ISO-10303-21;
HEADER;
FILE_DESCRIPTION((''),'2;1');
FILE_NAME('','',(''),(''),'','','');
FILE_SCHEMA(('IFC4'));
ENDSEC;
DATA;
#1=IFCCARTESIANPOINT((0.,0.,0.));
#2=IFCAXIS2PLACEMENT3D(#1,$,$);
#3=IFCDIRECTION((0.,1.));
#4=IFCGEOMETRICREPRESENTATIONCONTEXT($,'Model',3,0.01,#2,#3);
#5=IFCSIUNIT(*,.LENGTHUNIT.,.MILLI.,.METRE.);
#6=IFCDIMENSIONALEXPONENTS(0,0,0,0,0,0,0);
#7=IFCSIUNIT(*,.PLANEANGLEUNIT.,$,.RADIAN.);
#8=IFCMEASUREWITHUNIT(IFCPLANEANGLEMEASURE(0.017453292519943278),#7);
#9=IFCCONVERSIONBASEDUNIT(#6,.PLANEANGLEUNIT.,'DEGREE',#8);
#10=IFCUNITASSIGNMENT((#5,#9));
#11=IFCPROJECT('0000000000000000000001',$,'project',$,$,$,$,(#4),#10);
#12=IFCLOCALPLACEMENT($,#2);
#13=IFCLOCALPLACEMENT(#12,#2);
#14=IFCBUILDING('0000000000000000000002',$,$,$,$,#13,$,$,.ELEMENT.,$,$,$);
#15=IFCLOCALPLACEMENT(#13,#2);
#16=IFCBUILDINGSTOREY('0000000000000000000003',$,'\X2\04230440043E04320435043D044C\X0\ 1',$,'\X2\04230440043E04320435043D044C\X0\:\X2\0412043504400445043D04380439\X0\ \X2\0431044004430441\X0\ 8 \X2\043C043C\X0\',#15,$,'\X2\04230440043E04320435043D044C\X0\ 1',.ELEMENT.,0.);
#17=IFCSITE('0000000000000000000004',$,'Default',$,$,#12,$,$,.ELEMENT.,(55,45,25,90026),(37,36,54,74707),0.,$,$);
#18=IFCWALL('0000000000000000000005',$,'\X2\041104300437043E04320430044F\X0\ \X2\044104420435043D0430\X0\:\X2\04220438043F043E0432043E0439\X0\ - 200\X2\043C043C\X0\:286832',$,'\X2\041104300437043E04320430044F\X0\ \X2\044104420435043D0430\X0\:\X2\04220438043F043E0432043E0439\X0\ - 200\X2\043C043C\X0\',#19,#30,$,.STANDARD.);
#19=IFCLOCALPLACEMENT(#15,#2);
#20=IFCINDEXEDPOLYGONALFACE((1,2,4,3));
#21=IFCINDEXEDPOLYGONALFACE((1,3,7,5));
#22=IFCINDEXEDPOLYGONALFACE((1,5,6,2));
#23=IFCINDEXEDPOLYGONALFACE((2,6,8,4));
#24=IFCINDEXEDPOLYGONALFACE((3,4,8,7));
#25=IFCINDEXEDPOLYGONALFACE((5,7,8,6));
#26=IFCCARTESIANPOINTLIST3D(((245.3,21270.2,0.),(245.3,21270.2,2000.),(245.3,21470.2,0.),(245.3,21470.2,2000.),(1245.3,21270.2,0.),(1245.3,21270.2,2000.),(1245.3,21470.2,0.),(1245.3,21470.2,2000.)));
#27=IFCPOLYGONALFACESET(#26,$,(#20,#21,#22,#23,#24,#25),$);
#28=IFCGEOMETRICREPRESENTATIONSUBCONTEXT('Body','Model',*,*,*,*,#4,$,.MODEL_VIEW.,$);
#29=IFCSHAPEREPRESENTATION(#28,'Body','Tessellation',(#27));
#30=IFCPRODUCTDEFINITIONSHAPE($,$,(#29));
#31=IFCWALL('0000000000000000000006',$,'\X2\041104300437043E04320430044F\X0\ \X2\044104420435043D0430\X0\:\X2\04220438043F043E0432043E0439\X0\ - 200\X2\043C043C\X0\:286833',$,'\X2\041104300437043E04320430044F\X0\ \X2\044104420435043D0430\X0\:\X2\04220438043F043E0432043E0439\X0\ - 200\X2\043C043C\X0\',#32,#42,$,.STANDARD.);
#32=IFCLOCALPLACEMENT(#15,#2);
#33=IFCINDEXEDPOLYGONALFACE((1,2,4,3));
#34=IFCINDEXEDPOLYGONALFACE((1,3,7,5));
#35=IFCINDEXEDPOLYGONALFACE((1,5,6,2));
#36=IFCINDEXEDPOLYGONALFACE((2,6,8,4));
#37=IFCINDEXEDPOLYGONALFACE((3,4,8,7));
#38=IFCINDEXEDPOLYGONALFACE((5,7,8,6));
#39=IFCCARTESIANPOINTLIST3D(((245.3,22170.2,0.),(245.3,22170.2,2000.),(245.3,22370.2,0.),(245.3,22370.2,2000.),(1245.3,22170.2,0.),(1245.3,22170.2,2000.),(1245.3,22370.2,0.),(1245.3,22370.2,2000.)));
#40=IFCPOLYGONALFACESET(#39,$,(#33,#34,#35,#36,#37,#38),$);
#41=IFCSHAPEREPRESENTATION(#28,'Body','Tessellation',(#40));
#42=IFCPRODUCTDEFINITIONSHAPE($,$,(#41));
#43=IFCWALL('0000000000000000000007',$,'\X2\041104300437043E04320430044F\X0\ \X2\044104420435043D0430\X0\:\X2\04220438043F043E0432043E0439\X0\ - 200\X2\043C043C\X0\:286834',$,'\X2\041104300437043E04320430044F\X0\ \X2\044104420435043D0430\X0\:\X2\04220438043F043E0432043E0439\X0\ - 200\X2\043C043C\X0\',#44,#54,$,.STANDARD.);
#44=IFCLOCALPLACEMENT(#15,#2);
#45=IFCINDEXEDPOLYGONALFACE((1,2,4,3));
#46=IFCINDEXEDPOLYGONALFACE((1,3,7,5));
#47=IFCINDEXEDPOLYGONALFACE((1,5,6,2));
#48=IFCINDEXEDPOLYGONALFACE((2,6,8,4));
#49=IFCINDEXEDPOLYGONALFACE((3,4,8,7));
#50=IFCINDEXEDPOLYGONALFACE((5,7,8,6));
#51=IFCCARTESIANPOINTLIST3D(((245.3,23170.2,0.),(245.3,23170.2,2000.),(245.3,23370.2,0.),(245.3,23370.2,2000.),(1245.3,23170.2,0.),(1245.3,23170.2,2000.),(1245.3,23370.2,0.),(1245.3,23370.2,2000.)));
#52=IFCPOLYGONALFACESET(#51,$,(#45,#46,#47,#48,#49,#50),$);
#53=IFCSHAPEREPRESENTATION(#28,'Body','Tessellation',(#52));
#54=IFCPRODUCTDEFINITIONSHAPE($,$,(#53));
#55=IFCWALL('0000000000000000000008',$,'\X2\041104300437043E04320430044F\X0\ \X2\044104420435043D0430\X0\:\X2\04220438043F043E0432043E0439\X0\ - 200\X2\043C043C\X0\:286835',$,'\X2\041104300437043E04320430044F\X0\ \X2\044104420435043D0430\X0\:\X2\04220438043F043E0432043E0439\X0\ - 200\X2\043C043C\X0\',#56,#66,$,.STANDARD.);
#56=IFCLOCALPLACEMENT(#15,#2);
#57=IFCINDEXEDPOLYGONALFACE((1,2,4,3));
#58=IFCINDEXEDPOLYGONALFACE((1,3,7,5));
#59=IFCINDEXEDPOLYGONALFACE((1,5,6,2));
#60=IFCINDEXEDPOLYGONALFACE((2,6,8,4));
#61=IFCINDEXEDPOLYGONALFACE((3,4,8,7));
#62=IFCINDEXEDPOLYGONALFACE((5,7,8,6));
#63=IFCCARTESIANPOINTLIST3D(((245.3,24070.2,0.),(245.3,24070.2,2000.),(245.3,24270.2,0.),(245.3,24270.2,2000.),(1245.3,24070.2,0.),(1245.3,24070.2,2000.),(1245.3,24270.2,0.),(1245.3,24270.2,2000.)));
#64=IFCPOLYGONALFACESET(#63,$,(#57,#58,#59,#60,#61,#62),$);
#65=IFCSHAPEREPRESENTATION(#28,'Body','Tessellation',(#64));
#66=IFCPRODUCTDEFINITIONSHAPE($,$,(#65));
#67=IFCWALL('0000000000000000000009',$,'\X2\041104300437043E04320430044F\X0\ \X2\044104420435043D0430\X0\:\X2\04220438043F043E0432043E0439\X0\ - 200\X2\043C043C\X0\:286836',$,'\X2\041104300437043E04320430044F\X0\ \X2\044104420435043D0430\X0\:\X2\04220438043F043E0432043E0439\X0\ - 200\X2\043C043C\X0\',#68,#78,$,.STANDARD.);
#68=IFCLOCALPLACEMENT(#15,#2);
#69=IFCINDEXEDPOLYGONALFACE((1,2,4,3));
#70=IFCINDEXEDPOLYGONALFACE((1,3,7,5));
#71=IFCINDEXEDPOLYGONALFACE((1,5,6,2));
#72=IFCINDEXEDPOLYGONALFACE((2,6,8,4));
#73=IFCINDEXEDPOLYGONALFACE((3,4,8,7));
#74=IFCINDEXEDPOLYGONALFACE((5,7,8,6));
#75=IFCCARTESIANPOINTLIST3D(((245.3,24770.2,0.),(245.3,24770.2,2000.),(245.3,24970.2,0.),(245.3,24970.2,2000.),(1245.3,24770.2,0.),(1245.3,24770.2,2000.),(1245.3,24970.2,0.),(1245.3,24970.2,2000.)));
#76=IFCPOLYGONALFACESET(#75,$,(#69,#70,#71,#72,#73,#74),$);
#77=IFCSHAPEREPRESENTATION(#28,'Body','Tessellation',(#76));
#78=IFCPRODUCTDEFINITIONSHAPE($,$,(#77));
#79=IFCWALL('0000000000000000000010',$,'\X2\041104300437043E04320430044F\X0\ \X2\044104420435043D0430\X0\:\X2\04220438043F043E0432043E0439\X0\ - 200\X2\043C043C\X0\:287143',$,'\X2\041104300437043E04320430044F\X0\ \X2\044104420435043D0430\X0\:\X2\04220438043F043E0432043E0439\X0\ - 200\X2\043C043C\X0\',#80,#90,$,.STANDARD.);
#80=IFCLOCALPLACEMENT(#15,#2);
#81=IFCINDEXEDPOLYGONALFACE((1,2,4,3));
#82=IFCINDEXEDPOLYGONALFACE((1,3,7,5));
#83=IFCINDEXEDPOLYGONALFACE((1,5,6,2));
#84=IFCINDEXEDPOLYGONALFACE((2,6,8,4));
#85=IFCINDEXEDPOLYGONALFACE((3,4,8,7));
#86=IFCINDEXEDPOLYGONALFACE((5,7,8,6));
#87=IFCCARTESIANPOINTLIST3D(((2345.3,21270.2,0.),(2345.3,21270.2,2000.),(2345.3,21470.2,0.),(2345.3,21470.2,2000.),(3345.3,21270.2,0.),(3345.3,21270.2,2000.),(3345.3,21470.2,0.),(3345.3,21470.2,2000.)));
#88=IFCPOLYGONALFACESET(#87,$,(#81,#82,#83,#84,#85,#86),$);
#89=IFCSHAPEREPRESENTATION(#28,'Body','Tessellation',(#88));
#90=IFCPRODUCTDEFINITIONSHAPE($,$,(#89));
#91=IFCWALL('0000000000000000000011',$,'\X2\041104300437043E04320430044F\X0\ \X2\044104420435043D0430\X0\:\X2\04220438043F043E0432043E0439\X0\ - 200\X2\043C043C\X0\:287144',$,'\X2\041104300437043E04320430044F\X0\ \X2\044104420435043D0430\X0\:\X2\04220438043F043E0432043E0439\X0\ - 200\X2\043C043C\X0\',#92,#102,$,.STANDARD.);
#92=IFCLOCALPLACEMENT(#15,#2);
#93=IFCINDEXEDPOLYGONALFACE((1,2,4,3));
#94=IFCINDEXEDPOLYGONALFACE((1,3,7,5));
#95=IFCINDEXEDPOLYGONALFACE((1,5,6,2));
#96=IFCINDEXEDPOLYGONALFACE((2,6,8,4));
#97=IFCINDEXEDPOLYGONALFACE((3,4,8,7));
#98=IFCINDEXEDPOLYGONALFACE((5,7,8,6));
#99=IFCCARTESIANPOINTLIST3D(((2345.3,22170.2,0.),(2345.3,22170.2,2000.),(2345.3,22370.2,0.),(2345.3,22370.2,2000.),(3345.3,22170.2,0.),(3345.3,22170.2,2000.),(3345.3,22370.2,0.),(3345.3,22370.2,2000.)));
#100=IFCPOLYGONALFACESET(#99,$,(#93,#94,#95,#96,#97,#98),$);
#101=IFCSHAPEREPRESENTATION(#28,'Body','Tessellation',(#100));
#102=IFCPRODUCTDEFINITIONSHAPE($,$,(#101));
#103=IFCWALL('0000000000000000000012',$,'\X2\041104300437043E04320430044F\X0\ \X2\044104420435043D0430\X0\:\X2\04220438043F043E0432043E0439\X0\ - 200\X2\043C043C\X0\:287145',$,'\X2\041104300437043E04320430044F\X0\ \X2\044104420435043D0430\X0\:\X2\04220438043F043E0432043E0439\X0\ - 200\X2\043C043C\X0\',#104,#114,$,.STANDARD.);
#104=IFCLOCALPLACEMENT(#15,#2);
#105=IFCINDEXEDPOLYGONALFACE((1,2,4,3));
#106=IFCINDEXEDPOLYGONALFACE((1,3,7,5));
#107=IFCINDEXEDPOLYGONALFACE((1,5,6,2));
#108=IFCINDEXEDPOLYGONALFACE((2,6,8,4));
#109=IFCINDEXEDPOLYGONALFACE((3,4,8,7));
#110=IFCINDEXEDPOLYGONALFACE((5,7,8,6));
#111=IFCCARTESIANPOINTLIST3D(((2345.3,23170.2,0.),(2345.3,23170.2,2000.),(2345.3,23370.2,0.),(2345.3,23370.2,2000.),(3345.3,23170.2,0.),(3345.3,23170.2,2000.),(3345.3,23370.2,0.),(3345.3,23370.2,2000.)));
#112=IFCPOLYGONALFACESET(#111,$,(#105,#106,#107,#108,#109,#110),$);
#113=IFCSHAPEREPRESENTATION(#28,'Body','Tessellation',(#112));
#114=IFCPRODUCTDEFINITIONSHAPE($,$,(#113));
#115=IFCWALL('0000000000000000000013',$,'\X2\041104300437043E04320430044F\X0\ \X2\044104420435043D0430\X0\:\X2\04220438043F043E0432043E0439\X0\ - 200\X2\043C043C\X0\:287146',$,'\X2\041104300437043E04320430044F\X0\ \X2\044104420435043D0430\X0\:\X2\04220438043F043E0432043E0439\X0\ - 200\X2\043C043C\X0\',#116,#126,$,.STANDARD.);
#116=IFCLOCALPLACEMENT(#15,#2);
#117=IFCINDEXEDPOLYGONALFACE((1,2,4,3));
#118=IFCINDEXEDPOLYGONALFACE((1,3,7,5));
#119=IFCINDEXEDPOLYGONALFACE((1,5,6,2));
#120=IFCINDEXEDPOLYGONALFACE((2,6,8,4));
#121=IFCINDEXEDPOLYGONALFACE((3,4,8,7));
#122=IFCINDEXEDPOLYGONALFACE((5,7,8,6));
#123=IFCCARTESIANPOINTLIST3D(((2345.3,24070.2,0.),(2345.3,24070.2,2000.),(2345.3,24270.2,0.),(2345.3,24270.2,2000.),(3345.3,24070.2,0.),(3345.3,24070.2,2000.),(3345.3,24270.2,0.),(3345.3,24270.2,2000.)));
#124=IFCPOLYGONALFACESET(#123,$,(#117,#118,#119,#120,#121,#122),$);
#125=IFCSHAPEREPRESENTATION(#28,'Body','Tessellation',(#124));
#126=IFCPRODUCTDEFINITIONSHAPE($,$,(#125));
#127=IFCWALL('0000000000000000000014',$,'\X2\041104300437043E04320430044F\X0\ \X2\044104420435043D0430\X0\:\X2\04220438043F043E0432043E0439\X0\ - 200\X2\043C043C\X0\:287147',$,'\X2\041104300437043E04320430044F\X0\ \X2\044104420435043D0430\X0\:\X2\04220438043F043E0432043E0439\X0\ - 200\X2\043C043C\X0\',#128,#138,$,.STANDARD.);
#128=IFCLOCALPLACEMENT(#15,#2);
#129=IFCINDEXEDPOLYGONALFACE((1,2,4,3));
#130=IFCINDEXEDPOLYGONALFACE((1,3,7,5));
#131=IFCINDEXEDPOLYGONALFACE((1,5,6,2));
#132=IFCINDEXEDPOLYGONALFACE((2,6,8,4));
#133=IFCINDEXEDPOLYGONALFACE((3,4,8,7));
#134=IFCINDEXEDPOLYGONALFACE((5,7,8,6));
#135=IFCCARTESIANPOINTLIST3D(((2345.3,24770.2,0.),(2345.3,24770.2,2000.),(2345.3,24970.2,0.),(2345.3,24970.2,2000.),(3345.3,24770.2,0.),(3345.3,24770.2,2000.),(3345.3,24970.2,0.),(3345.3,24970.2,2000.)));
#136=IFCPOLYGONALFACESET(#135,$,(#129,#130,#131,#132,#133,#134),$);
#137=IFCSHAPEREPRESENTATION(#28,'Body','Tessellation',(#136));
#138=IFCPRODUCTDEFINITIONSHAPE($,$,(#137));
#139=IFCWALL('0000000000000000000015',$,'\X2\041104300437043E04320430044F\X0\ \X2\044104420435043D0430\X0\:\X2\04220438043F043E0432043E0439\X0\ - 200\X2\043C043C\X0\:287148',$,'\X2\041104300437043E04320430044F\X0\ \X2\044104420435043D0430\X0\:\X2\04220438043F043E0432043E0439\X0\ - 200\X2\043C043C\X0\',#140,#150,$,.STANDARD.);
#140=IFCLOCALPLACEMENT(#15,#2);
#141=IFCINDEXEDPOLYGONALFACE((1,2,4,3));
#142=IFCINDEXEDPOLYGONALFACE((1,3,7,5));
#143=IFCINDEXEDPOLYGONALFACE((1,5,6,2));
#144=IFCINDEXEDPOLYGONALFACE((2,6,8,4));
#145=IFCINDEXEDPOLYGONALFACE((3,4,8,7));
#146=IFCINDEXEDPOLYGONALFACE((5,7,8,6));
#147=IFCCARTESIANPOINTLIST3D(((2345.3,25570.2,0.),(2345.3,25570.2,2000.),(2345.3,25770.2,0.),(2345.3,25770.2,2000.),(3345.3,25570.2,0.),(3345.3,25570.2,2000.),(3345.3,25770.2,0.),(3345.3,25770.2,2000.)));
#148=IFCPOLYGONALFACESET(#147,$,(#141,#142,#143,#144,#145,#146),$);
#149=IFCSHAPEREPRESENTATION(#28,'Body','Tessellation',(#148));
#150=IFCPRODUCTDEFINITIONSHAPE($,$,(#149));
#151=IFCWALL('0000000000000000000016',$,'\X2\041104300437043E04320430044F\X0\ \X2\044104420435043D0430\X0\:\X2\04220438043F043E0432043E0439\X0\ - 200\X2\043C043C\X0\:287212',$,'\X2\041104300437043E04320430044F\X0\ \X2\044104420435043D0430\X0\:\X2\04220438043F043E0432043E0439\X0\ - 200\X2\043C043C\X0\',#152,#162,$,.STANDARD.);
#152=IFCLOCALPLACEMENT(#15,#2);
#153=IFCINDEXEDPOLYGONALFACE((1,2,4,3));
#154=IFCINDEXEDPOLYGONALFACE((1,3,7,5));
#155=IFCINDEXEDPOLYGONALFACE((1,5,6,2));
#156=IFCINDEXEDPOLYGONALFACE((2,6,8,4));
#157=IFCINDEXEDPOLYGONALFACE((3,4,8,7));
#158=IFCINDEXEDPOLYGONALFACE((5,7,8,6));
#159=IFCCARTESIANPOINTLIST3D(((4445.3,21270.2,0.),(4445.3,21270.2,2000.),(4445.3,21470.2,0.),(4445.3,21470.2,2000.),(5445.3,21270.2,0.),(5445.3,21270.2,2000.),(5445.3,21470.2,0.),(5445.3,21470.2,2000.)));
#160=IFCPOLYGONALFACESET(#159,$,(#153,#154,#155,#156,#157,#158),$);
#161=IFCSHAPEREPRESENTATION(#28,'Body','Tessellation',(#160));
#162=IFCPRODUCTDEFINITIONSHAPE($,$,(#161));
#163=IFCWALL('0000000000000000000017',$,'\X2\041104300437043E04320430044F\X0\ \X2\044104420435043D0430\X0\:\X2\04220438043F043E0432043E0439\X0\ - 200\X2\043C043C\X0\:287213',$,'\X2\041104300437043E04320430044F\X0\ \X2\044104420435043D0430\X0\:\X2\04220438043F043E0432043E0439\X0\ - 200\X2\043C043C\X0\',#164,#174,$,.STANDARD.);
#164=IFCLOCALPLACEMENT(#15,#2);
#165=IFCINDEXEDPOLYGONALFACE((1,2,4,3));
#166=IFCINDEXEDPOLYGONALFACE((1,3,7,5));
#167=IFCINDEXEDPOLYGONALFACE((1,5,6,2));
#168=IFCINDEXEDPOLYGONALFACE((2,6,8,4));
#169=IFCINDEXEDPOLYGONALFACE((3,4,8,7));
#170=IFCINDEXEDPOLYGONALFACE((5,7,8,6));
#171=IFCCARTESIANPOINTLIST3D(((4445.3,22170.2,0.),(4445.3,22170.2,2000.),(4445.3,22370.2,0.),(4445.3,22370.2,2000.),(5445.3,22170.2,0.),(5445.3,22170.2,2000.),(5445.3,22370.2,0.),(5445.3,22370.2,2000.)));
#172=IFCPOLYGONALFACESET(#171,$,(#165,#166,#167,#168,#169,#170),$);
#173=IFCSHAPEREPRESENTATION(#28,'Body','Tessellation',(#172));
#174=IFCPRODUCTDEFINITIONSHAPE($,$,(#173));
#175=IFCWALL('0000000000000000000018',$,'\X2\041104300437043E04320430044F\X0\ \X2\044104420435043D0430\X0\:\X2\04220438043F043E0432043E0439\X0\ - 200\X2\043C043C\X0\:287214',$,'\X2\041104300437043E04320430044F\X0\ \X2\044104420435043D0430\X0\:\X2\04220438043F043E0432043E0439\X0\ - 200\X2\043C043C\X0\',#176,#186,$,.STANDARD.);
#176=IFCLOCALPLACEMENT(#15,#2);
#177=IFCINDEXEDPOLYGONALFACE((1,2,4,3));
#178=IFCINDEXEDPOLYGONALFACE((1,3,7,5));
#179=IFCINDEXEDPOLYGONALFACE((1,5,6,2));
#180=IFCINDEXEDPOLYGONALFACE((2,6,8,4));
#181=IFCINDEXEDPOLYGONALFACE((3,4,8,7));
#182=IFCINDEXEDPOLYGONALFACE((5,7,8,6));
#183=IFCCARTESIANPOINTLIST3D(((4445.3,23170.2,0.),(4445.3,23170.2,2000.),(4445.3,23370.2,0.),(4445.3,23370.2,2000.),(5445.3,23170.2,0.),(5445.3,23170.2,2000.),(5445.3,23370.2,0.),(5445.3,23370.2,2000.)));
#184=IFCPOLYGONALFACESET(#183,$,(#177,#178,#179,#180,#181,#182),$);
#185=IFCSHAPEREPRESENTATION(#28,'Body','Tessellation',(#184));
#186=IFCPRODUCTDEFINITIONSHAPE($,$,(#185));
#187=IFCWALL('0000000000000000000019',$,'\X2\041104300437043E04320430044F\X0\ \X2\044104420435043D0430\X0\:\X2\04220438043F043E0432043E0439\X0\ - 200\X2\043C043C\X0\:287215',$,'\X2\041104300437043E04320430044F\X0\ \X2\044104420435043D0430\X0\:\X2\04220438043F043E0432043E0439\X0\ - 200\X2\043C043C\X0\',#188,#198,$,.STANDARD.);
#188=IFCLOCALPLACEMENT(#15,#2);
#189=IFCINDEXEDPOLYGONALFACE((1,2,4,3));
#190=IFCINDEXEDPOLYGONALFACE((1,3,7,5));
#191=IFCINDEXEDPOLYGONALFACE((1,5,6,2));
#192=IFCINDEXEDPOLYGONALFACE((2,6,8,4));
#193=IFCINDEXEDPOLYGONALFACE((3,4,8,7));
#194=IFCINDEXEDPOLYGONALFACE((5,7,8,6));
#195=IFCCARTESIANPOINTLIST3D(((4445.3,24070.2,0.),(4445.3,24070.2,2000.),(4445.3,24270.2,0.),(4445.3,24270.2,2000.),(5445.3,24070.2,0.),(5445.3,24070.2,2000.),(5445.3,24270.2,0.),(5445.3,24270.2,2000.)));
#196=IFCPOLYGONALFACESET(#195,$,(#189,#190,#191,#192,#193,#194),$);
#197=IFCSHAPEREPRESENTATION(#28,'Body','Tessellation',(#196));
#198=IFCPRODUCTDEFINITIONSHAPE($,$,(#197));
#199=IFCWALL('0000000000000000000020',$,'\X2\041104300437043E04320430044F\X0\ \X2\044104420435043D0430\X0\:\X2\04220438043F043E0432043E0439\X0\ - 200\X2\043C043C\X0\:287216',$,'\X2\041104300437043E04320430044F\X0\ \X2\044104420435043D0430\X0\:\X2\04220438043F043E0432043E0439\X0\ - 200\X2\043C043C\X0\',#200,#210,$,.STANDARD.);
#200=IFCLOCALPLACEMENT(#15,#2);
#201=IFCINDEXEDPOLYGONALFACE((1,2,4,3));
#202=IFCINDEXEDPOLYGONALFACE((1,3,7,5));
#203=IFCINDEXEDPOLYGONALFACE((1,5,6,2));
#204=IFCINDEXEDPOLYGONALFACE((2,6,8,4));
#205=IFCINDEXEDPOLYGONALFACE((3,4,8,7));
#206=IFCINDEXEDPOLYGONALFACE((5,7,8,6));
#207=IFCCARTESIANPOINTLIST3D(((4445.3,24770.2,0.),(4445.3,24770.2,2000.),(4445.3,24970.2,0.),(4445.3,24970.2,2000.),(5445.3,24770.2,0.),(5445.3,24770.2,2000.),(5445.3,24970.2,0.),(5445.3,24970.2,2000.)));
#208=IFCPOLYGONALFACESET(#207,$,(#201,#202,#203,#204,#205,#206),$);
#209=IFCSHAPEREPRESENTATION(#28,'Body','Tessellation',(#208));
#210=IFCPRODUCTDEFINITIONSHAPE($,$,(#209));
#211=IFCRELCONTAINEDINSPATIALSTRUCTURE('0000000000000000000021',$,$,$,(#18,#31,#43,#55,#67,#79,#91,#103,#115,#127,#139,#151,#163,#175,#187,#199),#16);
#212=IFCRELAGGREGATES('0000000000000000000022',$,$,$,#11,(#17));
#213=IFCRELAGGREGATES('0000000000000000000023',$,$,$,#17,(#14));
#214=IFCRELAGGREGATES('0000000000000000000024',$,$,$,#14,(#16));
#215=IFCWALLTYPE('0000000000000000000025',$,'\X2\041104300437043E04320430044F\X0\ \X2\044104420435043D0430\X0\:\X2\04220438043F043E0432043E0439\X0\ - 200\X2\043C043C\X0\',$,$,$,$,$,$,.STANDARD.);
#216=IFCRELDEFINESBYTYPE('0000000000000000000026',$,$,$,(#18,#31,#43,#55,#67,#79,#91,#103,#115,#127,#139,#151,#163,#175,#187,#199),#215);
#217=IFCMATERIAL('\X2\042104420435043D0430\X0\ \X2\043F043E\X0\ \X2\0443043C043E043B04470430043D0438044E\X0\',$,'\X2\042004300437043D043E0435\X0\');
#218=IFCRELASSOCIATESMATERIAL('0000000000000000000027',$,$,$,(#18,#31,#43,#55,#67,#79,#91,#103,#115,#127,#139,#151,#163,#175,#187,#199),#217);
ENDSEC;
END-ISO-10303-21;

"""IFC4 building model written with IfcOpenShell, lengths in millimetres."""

from ifc_helpers import new_model, entity, si_unit, converted_unit, direction, frame, origin, place, context, subcontext, project, spatial, indexed_curve, outline, extrude, material, type_object, element, save


model = new_model("IFC4")

# Units and contexts
model_context = context("Model", 3, precision=0.01, world=origin(), true_north=direction((0.0, 1.0)))
body_context = subcontext(model_context, "Body", "Model", "MODEL_VIEW")
ifc_project = project(units=[si_unit("LENGTHUNIT", "METRE", prefix="MILLI"), converted_unit("PLANEANGLEUNIT", "DEGREE", entity("IfcPlaneAngleMeasure", 0.017453292519943278), si_unit("PLANEANGLEUNIT", "RADIAN"), dimensions=[0, 0, 0, 0, 0, 0, 0])], contexts=[model_context])

# Site, building, storey
site_placement = place(None, origin())
site = spatial("IfcSite", under=ifc_project, at=site_placement, Name="Default", CompositionType="ELEMENT", RefLatitude=(55, 45, 25, 90026), RefLongitude=(37, 36, 54, 74707), RefElevation=0.0)
building_placement = place(site_placement, origin())
building = spatial("IfcBuilding", under=site, at=building_placement, CompositionType="ELEMENT")
storey_placement = place(building_placement, origin())
storey = spatial("IfcBuildingStorey", under=building, at=storey_placement, Name="Уровень 1", ObjectType="Уровень:Верхний брус 8 мм", LongName="Уровень 1", CompositionType="ELEMENT", Elevation=0.0)

# Walls
ifc_material = material(Name="Стена по умолчанию", Category="Разное")
wall_type = type_object("IfcWallType", Name="Базовая стена:Типовой - 200мм", PredefinedType="STANDARD")
for number, where, name in (
    (1, (245.3, 21370.2, 0.0), "Базовая стена:Типовой - 200мм:286832"),
    (2, (245.3, 22270.2, 0.0), "Базовая стена:Типовой - 200мм:286833"),
):
    element("IfcWall", number, at=place(storey_placement, frame(where)), inside=storey, type_object=wall_type, material=ifc_material, Name=name, ObjectType="Базовая стена:Типовой - 200мм", PredefinedType="STANDARD", context=body_context, shape_type="SweptSolid", body=[
        extrude(outline(indexed_curve([(1000.0, 100.0), (0.0, 100.0), (0.0, -100.0), (1000.0, -100.0), (1000.0, 100.0)], self_intersect=False)), origin(), (0.0, 0.0, 1.0), 2000.0),
    ])
for number, where, name in (
    (3, (245.3, 23270.2, 0.0), "Базовая стена:Типовой - 200мм:286834"),
    (4, (245.3, 24170.2, 0.0), "Базовая стена:Типовой - 200мм:286835"),
):
    element("IfcWall", number, at=place(storey_placement, frame(where)), inside=storey, type_object=wall_type, material=ifc_material, Name=name, ObjectType="Базовая стена:Типовой - 200мм", PredefinedType="STANDARD", context=body_context, shape_type="SweptSolid", body=[
        extrude(outline(indexed_curve([(1000.0, 100.0), (0.0, 100.0), (0.0, -100.0), (1000.0, -100.0), (1000.0, 100.0)], self_intersect=False)), origin(), (0.0, 0.0, 1.0), 2000.0),
    ])
wall_1_placement = place(storey_placement, frame((245.3, 24870.2, 0.0)))
element("IfcWall", 5, at=wall_1_placement, inside=storey, type_object=wall_type, material=ifc_material, Name="Базовая стена:Типовой - 200мм:286836", ObjectType="Базовая стена:Типовой - 200мм", PredefinedType="STANDARD", context=body_context, shape_type="SweptSolid", body=[
    extrude(outline(indexed_curve([(1000.0, 100.0), (0.0, 100.0), (0.0, -100.0), (1000.0, -100.0), (1000.0, 100.0)], self_intersect=False)), origin(), (0.0, 0.0, 1.0), 2000.0),
])
for number, where, name in (
    (6, (2345.3, 21370.2, 0.0), "Базовая стена:Типовой - 200мм:287143"),
    (7, (2345.3, 22270.2, 0.0), "Базовая стена:Типовой - 200мм:287144"),
):
    element("IfcWall", number, at=place(storey_placement, frame(where)), inside=storey, type_object=wall_type, material=ifc_material, Name=name, ObjectType="Базовая стена:Типовой - 200мм", PredefinedType="STANDARD", context=body_context, shape_type="SweptSolid", body=[
        extrude(outline(indexed_curve([(1000.0, 100.0), (0.0, 100.0), (0.0, -100.0), (1000.0, -100.0), (1000.0, 100.0)], self_intersect=False)), origin(), (0.0, 0.0, 1.0), 2000.0),
    ])
for number, where, name in (
    (8, (2345.3, 23270.2, 0.0), "Базовая стена:Типовой - 200мм:287145"),
    (9, (2345.3, 24170.2, 0.0), "Базовая стена:Типовой - 200мм:287146"),
    (10, (2345.3, 24870.2, 0.0), "Базовая стена:Типовой - 200мм:287147"),
):
    element("IfcWall", number, at=place(storey_placement, frame(where)), inside=storey, type_object=wall_type, material=ifc_material, Name=name, ObjectType="Базовая стена:Типовой - 200мм", PredefinedType="STANDARD", context=body_context, shape_type="SweptSolid", body=[
        extrude(outline(indexed_curve([(1000.0, 100.0), (0.0, 100.0), (0.0, -100.0), (1000.0, -100.0), (1000.0, 100.0)], self_intersect=False)), origin(), (0.0, 0.0, 1.0), 2000.0),
    ])
wall_2_placement = place(storey_placement, frame((2345.3, 25670.2, 0.0)))
element("IfcWall", 11, at=wall_2_placement, inside=storey, type_object=wall_type, material=ifc_material, Name="Базовая стена:Типовой - 200мм:287148", ObjectType="Базовая стена:Типовой - 200мм", PredefinedType="STANDARD", context=body_context, shape_type="SweptSolid", body=[
    extrude(outline(indexed_curve([(1000.0, 100.0), (0.0, 100.0), (0.0, -100.0), (1000.0, -100.0), (1000.0, 100.0)], self_intersect=False)), origin(), (0.0, 0.0, 1.0), 2000.0),
])
for number, where, name in (
    (12, (4445.3, 21370.2, 0.0), "Базовая стена:Типовой - 200мм:287212"),
    (13, (4445.3, 22270.2, 0.0), "Базовая стена:Типовой - 200мм:287213"),
):
    element("IfcWall", number, at=place(storey_placement, frame(where)), inside=storey, type_object=wall_type, material=ifc_material, Name=name, ObjectType="Базовая стена:Типовой - 200мм", PredefinedType="STANDARD", context=body_context, shape_type="SweptSolid", body=[
        extrude(outline(indexed_curve([(1000.0, 100.0), (0.0, 100.0), (0.0, -100.0), (1000.0, -100.0), (1000.0, 100.0)], self_intersect=False)), origin(), (0.0, 0.0, 1.0), 2000.0),
    ])
for number, where, name in (
    (14, (4445.3, 23270.2, 0.0), "Базовая стена:Типовой - 200мм:287214"),
    (15, (4445.3, 24170.2, 0.0), "Базовая стена:Типовой - 200мм:287215"),
    (16, (4445.3, 24870.2, 0.0), "Базовая стена:Типовой - 200мм:287216"),
):
    element("IfcWall", number, at=place(storey_placement, frame(where)), inside=storey, type_object=wall_type, material=ifc_material, Name=name, ObjectType="Базовая стена:Типовой - 200мм", PredefinedType="STANDARD", context=body_context, shape_type="SweptSolid", body=[
        extrude(outline(indexed_curve([(1000.0, 100.0), (0.0, 100.0), (0.0, -100.0), (1000.0, -100.0), (1000.0, 100.0)], self_intersect=False)), origin(), (0.0, 0.0, 1.0), 2000.0),
    ])

save(model, "model.ifc")
